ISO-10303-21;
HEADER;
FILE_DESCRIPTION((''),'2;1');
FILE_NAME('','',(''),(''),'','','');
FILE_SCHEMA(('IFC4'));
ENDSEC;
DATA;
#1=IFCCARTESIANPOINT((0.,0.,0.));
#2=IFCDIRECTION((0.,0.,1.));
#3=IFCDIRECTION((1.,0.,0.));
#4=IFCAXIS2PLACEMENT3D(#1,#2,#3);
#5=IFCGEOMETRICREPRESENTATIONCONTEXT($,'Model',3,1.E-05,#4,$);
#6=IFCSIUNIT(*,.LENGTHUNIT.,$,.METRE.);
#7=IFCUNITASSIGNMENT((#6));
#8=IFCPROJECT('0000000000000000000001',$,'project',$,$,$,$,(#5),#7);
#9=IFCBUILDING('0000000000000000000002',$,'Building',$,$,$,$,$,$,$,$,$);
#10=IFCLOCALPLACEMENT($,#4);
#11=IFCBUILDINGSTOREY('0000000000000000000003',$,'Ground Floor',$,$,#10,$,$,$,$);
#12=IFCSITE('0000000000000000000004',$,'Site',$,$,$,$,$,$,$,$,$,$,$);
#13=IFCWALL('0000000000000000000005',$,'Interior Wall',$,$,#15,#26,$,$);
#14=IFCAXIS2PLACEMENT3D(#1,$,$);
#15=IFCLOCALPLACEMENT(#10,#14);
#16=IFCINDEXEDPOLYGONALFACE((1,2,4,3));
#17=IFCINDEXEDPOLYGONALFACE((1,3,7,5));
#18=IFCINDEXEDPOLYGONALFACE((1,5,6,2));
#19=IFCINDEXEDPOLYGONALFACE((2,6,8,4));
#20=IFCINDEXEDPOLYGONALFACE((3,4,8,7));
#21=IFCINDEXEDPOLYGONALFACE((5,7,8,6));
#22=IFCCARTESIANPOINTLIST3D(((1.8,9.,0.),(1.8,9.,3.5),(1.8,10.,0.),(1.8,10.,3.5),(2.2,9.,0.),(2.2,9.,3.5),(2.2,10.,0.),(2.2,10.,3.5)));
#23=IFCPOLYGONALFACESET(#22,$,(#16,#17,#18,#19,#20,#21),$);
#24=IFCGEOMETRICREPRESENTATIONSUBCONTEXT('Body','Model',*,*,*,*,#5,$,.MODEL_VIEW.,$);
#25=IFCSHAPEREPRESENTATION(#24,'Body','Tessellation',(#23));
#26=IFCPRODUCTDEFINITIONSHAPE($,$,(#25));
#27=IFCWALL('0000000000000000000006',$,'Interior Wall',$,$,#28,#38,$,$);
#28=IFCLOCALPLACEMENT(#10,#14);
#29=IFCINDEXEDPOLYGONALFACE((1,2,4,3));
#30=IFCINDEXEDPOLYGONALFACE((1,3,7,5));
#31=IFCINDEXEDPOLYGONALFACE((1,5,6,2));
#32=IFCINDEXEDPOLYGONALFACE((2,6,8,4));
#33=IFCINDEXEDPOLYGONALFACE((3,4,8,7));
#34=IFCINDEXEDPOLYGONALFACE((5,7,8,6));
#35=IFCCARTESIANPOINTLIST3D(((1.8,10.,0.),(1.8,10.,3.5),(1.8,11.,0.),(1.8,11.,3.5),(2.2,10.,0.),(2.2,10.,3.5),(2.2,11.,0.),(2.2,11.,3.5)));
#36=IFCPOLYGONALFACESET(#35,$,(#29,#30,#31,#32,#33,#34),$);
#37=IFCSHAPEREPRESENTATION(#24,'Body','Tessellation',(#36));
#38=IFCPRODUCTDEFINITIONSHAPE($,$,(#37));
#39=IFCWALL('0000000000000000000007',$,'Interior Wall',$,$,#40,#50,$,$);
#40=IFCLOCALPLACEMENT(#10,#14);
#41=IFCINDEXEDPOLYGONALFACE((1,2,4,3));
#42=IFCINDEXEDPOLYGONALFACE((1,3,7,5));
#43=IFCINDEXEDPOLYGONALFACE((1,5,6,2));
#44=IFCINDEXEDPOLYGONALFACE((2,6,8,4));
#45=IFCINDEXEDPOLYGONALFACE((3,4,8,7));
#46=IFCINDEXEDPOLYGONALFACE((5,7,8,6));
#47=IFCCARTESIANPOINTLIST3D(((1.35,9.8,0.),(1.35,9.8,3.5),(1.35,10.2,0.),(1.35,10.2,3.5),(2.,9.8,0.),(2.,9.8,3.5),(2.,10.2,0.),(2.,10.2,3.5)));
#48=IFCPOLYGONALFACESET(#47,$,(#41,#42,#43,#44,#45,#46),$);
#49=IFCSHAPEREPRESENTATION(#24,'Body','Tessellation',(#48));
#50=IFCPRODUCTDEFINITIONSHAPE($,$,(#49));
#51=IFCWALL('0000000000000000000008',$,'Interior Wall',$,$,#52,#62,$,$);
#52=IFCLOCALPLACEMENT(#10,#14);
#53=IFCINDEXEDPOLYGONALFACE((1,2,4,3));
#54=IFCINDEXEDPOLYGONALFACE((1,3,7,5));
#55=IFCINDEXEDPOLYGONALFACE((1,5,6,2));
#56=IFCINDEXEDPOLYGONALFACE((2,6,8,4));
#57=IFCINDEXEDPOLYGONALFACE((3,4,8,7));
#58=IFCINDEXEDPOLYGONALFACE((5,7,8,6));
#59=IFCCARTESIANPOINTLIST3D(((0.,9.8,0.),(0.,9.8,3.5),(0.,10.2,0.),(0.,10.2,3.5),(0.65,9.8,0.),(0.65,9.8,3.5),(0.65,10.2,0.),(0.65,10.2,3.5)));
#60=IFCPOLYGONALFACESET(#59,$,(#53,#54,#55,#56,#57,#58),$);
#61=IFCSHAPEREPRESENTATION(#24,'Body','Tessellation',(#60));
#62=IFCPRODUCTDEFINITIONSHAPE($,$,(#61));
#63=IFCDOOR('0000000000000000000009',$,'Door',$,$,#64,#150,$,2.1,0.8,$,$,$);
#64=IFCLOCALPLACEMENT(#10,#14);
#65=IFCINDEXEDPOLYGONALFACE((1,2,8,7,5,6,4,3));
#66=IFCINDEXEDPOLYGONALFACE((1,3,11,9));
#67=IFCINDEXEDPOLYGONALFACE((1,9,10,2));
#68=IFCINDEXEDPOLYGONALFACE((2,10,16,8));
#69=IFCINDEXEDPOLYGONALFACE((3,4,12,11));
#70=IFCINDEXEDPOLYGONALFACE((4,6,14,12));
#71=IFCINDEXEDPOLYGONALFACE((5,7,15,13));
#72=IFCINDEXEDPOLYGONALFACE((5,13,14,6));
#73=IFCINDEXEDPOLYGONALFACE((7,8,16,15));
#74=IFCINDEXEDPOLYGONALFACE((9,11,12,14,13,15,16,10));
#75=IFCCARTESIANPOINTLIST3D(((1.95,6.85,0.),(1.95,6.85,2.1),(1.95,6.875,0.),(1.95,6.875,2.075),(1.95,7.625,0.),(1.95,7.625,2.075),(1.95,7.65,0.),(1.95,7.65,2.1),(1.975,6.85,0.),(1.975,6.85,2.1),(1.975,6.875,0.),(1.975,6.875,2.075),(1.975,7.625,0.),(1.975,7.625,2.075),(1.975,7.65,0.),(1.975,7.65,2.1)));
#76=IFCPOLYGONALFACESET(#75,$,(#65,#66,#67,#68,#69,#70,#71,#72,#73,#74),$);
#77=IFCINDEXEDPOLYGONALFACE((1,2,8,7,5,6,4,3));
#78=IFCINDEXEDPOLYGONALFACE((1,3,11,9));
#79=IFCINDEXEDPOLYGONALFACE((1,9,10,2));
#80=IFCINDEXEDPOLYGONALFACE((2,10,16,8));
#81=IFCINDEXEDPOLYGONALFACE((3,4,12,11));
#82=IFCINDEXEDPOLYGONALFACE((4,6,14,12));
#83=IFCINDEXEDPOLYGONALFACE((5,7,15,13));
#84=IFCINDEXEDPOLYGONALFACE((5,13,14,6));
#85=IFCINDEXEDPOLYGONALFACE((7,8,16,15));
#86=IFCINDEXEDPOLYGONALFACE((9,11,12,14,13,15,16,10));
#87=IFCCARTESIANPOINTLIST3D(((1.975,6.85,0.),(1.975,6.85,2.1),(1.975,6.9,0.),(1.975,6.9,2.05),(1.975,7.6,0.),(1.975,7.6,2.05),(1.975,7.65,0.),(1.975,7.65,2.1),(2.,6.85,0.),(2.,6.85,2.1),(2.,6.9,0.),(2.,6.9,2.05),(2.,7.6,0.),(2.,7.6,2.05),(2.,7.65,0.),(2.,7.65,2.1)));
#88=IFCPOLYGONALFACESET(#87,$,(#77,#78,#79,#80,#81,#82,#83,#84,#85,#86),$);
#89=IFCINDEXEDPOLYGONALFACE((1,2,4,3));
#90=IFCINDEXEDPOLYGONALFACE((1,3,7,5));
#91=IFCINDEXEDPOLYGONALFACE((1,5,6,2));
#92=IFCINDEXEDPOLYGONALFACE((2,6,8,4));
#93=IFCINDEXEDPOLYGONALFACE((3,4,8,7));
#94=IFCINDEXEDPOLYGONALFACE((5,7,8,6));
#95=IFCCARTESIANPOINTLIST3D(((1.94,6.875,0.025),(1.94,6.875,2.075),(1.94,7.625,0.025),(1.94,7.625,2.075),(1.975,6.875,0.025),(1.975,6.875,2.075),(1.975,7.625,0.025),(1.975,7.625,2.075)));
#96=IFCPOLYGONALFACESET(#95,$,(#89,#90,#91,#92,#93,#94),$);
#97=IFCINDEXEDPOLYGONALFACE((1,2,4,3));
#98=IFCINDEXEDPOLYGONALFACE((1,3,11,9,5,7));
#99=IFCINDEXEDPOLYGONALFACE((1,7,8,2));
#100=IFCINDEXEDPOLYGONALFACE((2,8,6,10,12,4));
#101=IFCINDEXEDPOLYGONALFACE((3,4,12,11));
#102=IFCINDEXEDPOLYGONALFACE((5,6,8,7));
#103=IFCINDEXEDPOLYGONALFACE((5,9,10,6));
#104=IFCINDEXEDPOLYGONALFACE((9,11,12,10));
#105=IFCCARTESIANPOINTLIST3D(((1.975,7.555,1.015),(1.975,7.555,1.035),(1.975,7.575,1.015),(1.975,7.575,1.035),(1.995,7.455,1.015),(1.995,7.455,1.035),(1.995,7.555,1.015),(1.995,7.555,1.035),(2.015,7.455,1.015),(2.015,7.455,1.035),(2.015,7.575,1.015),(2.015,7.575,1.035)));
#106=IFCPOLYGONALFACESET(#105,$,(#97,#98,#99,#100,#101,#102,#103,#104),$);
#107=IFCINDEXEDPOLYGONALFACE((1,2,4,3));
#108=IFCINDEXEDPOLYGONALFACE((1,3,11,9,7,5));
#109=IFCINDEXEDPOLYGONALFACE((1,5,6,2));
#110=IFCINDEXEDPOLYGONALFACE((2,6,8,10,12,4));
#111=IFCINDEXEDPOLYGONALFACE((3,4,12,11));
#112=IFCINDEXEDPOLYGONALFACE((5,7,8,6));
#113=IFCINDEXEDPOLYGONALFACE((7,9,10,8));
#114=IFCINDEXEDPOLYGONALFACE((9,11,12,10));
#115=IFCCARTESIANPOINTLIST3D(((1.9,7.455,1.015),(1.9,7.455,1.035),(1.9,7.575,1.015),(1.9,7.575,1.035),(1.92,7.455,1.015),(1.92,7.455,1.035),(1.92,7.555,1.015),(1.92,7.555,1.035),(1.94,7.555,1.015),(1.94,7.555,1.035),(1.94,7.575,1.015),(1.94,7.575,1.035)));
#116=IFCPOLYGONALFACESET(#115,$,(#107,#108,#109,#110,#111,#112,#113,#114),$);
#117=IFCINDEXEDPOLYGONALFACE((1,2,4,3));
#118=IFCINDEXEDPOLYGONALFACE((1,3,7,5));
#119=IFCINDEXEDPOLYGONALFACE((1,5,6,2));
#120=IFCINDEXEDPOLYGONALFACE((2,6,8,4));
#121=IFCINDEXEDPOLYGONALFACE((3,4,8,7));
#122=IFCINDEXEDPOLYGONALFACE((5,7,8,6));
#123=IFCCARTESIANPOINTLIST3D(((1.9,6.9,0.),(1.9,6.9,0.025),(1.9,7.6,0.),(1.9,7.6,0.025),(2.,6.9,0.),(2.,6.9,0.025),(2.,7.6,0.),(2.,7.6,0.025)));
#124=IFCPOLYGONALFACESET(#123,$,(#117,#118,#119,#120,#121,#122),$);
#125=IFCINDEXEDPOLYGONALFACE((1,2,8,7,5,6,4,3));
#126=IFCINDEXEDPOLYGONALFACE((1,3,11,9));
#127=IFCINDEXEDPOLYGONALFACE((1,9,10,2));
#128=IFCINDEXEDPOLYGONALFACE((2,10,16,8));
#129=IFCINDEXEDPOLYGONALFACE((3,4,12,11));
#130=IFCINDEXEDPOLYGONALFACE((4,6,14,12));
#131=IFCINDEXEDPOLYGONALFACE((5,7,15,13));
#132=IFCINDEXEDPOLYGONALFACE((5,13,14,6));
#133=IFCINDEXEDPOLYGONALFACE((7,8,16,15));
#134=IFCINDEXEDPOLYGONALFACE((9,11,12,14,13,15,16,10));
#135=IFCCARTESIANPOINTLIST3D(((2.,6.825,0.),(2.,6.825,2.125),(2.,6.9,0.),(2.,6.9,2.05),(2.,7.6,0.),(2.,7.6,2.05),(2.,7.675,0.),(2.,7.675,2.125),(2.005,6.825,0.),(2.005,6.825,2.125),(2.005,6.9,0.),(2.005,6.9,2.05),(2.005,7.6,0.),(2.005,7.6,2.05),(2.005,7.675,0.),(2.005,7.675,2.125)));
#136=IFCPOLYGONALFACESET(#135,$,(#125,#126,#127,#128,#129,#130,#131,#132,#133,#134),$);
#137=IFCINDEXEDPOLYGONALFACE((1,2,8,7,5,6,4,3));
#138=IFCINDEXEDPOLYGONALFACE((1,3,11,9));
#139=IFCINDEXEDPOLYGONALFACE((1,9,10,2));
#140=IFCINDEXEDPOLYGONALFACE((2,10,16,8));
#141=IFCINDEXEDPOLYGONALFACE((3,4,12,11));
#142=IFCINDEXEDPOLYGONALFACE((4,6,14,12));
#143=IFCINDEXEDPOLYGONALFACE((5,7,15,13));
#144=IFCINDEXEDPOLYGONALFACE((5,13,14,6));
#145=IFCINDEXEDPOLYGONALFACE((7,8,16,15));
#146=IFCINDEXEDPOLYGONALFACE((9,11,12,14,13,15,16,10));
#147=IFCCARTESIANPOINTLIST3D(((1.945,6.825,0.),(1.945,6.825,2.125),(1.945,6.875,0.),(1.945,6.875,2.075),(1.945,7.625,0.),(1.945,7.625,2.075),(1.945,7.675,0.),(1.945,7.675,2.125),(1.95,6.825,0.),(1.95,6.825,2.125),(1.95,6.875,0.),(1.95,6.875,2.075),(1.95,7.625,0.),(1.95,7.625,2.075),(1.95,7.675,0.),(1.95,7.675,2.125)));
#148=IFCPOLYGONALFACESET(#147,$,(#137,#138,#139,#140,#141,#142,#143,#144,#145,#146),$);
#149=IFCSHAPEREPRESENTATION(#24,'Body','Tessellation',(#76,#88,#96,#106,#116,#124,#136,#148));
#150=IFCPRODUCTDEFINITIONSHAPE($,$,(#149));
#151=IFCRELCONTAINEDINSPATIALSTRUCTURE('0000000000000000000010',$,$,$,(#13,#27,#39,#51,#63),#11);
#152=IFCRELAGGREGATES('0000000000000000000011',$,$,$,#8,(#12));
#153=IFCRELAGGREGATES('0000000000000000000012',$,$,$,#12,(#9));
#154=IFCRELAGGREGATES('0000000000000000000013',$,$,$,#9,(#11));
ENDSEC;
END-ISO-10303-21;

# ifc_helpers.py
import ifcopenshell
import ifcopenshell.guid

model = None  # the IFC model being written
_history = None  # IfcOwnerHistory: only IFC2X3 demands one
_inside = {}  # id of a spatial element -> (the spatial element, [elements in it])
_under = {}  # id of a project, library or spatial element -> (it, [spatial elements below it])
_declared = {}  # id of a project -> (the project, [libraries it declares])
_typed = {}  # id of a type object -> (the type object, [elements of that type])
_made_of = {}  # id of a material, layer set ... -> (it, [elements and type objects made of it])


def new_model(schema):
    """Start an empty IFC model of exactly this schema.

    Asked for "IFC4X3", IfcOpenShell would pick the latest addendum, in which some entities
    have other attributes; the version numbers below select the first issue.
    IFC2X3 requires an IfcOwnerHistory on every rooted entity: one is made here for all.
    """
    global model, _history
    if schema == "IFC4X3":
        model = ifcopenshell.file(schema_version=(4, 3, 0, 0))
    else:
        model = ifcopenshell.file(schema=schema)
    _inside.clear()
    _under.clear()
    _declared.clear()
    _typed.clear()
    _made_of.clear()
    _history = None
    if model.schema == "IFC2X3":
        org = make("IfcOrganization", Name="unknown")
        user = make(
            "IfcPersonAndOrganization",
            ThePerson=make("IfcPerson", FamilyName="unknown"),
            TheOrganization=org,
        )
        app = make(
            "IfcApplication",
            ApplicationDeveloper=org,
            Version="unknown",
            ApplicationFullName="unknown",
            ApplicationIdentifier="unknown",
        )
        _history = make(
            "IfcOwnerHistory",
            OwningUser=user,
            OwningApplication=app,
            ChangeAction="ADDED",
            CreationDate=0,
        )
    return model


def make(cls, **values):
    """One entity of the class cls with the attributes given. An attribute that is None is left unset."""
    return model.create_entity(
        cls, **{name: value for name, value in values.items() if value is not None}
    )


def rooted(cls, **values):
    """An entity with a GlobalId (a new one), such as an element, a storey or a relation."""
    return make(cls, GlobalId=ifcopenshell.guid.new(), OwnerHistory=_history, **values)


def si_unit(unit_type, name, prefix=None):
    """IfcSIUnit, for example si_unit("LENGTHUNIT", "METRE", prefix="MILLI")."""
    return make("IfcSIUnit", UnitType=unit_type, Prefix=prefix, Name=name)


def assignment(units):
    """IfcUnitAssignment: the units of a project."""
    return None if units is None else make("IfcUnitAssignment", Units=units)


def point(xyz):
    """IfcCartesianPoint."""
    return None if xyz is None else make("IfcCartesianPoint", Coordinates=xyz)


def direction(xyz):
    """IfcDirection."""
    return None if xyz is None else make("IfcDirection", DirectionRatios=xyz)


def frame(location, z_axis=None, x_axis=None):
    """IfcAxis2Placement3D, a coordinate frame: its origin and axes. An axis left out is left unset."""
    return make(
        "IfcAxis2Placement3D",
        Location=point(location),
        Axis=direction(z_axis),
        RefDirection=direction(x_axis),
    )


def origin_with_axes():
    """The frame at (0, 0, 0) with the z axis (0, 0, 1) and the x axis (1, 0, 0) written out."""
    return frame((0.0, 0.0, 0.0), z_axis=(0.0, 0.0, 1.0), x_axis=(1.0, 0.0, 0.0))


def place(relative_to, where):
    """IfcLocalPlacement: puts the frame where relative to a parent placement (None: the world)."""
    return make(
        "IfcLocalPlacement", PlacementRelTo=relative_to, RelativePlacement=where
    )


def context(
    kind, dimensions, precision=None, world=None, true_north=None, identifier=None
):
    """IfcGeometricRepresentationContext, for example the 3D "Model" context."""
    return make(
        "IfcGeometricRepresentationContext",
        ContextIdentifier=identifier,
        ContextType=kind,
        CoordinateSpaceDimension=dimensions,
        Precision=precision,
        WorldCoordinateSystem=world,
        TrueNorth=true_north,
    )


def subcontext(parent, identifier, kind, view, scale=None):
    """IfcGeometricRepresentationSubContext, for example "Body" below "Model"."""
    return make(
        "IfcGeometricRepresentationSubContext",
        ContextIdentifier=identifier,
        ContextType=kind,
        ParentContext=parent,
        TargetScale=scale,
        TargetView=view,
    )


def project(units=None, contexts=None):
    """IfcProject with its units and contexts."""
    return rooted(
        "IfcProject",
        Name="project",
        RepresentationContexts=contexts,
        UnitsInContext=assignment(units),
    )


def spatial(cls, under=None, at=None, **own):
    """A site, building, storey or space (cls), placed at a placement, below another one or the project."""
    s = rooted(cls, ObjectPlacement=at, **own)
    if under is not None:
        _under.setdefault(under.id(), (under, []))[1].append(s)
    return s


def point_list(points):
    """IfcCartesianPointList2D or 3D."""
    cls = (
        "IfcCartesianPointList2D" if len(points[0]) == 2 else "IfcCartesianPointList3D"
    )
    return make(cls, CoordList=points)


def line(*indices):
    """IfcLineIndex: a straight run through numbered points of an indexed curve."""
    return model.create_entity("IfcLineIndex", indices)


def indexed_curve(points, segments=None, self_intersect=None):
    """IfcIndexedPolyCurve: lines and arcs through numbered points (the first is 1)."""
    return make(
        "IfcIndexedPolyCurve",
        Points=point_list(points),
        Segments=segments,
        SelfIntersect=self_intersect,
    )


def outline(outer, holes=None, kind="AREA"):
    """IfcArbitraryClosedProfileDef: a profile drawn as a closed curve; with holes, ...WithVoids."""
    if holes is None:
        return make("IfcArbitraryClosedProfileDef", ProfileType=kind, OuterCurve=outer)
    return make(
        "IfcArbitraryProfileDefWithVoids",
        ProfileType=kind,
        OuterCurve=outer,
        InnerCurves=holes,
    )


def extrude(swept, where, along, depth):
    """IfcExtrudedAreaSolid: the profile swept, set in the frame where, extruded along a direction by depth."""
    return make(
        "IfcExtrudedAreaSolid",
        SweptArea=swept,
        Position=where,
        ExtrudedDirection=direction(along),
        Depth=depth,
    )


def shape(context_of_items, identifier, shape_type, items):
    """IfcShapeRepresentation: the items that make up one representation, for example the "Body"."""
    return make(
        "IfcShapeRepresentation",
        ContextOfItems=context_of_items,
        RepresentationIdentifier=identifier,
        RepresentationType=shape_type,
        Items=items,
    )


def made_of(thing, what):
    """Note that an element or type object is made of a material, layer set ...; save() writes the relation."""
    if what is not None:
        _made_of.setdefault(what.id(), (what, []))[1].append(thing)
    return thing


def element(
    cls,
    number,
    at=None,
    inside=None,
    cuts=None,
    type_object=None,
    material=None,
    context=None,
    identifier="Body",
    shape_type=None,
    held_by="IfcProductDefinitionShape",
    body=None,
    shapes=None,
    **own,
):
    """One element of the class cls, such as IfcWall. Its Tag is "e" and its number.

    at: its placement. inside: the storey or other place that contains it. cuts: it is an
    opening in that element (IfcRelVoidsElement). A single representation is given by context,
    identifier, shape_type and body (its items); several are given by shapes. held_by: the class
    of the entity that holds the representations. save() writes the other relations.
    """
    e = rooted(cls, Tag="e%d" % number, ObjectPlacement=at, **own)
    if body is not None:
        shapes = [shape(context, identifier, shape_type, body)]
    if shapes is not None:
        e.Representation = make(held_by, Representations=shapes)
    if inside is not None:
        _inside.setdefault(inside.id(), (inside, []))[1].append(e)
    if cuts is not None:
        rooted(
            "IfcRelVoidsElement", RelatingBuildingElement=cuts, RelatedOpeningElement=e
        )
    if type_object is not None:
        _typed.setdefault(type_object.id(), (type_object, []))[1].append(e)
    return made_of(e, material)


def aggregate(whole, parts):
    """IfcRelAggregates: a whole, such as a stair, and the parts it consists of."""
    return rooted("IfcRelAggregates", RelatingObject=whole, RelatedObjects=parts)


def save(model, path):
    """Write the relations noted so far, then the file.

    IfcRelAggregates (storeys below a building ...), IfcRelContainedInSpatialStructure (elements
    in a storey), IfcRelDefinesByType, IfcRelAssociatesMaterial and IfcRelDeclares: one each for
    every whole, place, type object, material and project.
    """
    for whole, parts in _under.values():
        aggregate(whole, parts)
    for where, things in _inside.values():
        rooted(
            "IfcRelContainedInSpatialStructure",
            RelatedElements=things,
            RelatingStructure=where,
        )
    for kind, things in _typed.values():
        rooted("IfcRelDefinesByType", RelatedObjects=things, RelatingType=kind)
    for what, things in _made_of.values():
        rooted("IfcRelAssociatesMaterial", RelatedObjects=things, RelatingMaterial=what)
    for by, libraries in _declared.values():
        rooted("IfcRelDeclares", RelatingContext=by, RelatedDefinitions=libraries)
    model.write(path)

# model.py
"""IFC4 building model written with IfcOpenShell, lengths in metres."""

from ifc_helpers import new_model, si_unit, frame, origin_with_axes, place, context, subcontext, project, spatial, line, indexed_curve, outline, extrude, element, save


model = new_model("IFC4")

# Units and contexts
model_context = context("Model", 3, precision=1e-05, world=origin_with_axes())
body_context = subcontext(model_context, "Body", "Model", "MODEL_VIEW")
ifc_project = project(units=[si_unit("LENGTHUNIT", "METRE")], contexts=[model_context])

# Site, building, storey
site = spatial("IfcSite", under=ifc_project, Name="Site")
building = spatial("IfcBuilding", under=site, Name="Building")
storey_placement = place(None, origin_with_axes())
storey = spatial("IfcBuildingStorey", under=building, at=storey_placement, Name="Ground Floor")

# Walls
for number, where, z_axis, x_axis, name in (
    (1, (2.0, 10.0, 0.0), (0.0, 0.0, 1.0), (0.0, -1.0, 0.0), "Interior Wall"),
    (2, (2.0, 11.0, 0.0), (0.0, 0.0, 1.0), (0.0, -1.0, 0.0), "Interior Wall"),
):
    element("IfcWall", number, at=place(storey_placement, frame(where, z_axis=z_axis, x_axis=x_axis)), inside=storey, Name=name, context=body_context, shape_type="SweptSolid", body=[
        extrude(outline(indexed_curve([(0.0, 0.0), (0.0, 0.4), (1.0, 0.4), (1.0, 0.0), (0.0, 0.0)], self_intersect=False)), frame((0.0, -0.2, 0.0), z_axis=(0.0, 0.0, 1.0), x_axis=(1.0, 0.0, 0.0)), (0.0, 0.0, 1.0), 3.5),
    ])
for number, where, z_axis, x_axis, name in (
    (3, (2.0, 10.0, 0.0), (0.0, 0.0, 1.0), (-1.0, 0.0, 0.0), "Interior Wall"),
    (4, (0.65, 10.0, 0.0), (0.0, 0.0, 1.0), (-1.0, 0.0, 0.0), "Interior Wall"),
):
    element("IfcWall", number, at=place(storey_placement, frame(where, z_axis=z_axis, x_axis=x_axis)), inside=storey, Name=name, context=body_context, shape_type="SweptSolid", body=[
        extrude(outline(indexed_curve([(0.0, 0.0), (0.0, 0.4), (0.65, 0.4), (0.65, 0.0), (0.0, 0.0)], self_intersect=False)), frame((0.0, -0.2, 0.0), z_axis=(0.0, 0.0, 1.0), x_axis=(1.0, 0.0, 0.0)), (0.0, 0.0, 1.0), 3.5),
    ])

# Door
door_1_placement = place(storey_placement, frame((2.0, 6.85, 0.0), z_axis=(0.0, 0.0, 1.0), x_axis=(0.0, 1.0, 0.0)))
element("IfcDoor", 5, at=door_1_placement, inside=storey, Name="Door", OverallHeight=2.1, OverallWidth=0.8, context=body_context, shape_type="SweptSolid", body=[
    extrude(outline(indexed_curve([(0.0, 0.0), (0.0, 2.1), (0.8, 2.1), (0.8, 0.0), (0.775, 0.0), (0.775, 2.075), (0.025, 2.075), (0.025, 0.0)], segments=[line(1, 2, 3, 4, 5, 6, 7, 8, 1)])), frame((0.0, 0.025, 0.0), z_axis=(0.0, -1.0, 0.0), x_axis=(1.0, 0.0, 0.0)), (0.0, 0.0, -1.0), 0.025),
    extrude(outline(indexed_curve([(0.0, 0.0), (0.0, 2.1), (0.8, 2.1), (0.8, 0.0), (0.75, 0.0), (0.75, 2.05), (0.05, 2.05), (0.05, 0.0)], segments=[line(1, 2, 3, 4, 5, 6, 7, 8, 1)])), frame((0.0, 0.0, 0.0), z_axis=(0.0, -1.0, 0.0), x_axis=(1.0, 0.0, 0.0)), (0.0, 0.0, -1.0), 0.025),
    extrude(outline(indexed_curve([(0.0, 0.0), (0.75, 0.0), (0.75, 0.035), (0.0, 0.035)], segments=[line(1, 2, 3, 4, 1)])), frame((0.025, 0.025, 0.025), z_axis=(0.0, 0.0, 1.0), x_axis=(1.0, 0.0, 0.0)), (0.0, 0.0, 1.0), 2.05),
    extrude(outline(indexed_curve([(0.0, 0.0), (0.0, -0.04), (-0.12, -0.04), (-0.12, -0.02), (-0.02, -0.02), (-0.02, 0.0)], segments=[line(1, 2, 3, 4, 5, 6, 1)])), frame((0.725, 0.025, 1.015), z_axis=(0.0, 0.0, 1.0), x_axis=(1.0, 0.0, 0.0)), (0.0, 0.0, 1.0), 0.02),
    extrude(outline(indexed_curve([(0.0, 0.0), (0.0, 0.04), (-0.12, 0.04), (-0.12, 0.02), (-0.02, 0.02), (-0.02, 0.0)], segments=[line(1, 2, 3, 4, 5, 6, 1)])), frame((0.725, 0.06, 1.015), z_axis=(0.0, 0.0, 1.0), x_axis=(1.0, 0.0, 0.0)), (0.0, 0.0, 1.0), 0.02),
    extrude(outline(indexed_curve([(0.0, 0.0), (0.7, 0.0), (0.7, 0.1), (0.0, 0.1)], segments=[line(1, 2, 3, 4, 1)])), frame((0.05, 0.0, 0.0), z_axis=(0.0, 0.0, 1.0), x_axis=(1.0, 0.0, 0.0)), (0.0, 0.0, 1.0), 0.025),
    extrude(outline(indexed_curve([(0.0, 0.0), (0.0, 2.125), (0.85, 2.125), (0.85, 0.0), (0.775, 0.0), (0.775, 2.05), (0.075, 2.05), (0.075, 0.0)], segments=[line(1, 2, 3, 4, 5, 6, 7, 8, 1)])), frame((-0.025, -0.005, 0.0), z_axis=(0.0, -1.0, 0.0), x_axis=(1.0, 0.0, 0.0)), (0.0, 0.0, -1.0), 0.005),
    extrude(outline(indexed_curve([(0.0, 0.0), (0.0, 2.125), (0.85, 2.125), (0.85, 0.0), (0.8, 0.0), (0.8, 2.075), (0.05, 2.075), (0.05, 0.0)], segments=[line(1, 2, 3, 4, 5, 6, 7, 8, 1)])), frame((-0.025, 0.05, 0.0), z_axis=(0.0, -1.0, 0.0), x_axis=(1.0, 0.0, 0.0)), (0.0, 0.0, -1.0), 0.005),
])

save(model, "model.ifc")
